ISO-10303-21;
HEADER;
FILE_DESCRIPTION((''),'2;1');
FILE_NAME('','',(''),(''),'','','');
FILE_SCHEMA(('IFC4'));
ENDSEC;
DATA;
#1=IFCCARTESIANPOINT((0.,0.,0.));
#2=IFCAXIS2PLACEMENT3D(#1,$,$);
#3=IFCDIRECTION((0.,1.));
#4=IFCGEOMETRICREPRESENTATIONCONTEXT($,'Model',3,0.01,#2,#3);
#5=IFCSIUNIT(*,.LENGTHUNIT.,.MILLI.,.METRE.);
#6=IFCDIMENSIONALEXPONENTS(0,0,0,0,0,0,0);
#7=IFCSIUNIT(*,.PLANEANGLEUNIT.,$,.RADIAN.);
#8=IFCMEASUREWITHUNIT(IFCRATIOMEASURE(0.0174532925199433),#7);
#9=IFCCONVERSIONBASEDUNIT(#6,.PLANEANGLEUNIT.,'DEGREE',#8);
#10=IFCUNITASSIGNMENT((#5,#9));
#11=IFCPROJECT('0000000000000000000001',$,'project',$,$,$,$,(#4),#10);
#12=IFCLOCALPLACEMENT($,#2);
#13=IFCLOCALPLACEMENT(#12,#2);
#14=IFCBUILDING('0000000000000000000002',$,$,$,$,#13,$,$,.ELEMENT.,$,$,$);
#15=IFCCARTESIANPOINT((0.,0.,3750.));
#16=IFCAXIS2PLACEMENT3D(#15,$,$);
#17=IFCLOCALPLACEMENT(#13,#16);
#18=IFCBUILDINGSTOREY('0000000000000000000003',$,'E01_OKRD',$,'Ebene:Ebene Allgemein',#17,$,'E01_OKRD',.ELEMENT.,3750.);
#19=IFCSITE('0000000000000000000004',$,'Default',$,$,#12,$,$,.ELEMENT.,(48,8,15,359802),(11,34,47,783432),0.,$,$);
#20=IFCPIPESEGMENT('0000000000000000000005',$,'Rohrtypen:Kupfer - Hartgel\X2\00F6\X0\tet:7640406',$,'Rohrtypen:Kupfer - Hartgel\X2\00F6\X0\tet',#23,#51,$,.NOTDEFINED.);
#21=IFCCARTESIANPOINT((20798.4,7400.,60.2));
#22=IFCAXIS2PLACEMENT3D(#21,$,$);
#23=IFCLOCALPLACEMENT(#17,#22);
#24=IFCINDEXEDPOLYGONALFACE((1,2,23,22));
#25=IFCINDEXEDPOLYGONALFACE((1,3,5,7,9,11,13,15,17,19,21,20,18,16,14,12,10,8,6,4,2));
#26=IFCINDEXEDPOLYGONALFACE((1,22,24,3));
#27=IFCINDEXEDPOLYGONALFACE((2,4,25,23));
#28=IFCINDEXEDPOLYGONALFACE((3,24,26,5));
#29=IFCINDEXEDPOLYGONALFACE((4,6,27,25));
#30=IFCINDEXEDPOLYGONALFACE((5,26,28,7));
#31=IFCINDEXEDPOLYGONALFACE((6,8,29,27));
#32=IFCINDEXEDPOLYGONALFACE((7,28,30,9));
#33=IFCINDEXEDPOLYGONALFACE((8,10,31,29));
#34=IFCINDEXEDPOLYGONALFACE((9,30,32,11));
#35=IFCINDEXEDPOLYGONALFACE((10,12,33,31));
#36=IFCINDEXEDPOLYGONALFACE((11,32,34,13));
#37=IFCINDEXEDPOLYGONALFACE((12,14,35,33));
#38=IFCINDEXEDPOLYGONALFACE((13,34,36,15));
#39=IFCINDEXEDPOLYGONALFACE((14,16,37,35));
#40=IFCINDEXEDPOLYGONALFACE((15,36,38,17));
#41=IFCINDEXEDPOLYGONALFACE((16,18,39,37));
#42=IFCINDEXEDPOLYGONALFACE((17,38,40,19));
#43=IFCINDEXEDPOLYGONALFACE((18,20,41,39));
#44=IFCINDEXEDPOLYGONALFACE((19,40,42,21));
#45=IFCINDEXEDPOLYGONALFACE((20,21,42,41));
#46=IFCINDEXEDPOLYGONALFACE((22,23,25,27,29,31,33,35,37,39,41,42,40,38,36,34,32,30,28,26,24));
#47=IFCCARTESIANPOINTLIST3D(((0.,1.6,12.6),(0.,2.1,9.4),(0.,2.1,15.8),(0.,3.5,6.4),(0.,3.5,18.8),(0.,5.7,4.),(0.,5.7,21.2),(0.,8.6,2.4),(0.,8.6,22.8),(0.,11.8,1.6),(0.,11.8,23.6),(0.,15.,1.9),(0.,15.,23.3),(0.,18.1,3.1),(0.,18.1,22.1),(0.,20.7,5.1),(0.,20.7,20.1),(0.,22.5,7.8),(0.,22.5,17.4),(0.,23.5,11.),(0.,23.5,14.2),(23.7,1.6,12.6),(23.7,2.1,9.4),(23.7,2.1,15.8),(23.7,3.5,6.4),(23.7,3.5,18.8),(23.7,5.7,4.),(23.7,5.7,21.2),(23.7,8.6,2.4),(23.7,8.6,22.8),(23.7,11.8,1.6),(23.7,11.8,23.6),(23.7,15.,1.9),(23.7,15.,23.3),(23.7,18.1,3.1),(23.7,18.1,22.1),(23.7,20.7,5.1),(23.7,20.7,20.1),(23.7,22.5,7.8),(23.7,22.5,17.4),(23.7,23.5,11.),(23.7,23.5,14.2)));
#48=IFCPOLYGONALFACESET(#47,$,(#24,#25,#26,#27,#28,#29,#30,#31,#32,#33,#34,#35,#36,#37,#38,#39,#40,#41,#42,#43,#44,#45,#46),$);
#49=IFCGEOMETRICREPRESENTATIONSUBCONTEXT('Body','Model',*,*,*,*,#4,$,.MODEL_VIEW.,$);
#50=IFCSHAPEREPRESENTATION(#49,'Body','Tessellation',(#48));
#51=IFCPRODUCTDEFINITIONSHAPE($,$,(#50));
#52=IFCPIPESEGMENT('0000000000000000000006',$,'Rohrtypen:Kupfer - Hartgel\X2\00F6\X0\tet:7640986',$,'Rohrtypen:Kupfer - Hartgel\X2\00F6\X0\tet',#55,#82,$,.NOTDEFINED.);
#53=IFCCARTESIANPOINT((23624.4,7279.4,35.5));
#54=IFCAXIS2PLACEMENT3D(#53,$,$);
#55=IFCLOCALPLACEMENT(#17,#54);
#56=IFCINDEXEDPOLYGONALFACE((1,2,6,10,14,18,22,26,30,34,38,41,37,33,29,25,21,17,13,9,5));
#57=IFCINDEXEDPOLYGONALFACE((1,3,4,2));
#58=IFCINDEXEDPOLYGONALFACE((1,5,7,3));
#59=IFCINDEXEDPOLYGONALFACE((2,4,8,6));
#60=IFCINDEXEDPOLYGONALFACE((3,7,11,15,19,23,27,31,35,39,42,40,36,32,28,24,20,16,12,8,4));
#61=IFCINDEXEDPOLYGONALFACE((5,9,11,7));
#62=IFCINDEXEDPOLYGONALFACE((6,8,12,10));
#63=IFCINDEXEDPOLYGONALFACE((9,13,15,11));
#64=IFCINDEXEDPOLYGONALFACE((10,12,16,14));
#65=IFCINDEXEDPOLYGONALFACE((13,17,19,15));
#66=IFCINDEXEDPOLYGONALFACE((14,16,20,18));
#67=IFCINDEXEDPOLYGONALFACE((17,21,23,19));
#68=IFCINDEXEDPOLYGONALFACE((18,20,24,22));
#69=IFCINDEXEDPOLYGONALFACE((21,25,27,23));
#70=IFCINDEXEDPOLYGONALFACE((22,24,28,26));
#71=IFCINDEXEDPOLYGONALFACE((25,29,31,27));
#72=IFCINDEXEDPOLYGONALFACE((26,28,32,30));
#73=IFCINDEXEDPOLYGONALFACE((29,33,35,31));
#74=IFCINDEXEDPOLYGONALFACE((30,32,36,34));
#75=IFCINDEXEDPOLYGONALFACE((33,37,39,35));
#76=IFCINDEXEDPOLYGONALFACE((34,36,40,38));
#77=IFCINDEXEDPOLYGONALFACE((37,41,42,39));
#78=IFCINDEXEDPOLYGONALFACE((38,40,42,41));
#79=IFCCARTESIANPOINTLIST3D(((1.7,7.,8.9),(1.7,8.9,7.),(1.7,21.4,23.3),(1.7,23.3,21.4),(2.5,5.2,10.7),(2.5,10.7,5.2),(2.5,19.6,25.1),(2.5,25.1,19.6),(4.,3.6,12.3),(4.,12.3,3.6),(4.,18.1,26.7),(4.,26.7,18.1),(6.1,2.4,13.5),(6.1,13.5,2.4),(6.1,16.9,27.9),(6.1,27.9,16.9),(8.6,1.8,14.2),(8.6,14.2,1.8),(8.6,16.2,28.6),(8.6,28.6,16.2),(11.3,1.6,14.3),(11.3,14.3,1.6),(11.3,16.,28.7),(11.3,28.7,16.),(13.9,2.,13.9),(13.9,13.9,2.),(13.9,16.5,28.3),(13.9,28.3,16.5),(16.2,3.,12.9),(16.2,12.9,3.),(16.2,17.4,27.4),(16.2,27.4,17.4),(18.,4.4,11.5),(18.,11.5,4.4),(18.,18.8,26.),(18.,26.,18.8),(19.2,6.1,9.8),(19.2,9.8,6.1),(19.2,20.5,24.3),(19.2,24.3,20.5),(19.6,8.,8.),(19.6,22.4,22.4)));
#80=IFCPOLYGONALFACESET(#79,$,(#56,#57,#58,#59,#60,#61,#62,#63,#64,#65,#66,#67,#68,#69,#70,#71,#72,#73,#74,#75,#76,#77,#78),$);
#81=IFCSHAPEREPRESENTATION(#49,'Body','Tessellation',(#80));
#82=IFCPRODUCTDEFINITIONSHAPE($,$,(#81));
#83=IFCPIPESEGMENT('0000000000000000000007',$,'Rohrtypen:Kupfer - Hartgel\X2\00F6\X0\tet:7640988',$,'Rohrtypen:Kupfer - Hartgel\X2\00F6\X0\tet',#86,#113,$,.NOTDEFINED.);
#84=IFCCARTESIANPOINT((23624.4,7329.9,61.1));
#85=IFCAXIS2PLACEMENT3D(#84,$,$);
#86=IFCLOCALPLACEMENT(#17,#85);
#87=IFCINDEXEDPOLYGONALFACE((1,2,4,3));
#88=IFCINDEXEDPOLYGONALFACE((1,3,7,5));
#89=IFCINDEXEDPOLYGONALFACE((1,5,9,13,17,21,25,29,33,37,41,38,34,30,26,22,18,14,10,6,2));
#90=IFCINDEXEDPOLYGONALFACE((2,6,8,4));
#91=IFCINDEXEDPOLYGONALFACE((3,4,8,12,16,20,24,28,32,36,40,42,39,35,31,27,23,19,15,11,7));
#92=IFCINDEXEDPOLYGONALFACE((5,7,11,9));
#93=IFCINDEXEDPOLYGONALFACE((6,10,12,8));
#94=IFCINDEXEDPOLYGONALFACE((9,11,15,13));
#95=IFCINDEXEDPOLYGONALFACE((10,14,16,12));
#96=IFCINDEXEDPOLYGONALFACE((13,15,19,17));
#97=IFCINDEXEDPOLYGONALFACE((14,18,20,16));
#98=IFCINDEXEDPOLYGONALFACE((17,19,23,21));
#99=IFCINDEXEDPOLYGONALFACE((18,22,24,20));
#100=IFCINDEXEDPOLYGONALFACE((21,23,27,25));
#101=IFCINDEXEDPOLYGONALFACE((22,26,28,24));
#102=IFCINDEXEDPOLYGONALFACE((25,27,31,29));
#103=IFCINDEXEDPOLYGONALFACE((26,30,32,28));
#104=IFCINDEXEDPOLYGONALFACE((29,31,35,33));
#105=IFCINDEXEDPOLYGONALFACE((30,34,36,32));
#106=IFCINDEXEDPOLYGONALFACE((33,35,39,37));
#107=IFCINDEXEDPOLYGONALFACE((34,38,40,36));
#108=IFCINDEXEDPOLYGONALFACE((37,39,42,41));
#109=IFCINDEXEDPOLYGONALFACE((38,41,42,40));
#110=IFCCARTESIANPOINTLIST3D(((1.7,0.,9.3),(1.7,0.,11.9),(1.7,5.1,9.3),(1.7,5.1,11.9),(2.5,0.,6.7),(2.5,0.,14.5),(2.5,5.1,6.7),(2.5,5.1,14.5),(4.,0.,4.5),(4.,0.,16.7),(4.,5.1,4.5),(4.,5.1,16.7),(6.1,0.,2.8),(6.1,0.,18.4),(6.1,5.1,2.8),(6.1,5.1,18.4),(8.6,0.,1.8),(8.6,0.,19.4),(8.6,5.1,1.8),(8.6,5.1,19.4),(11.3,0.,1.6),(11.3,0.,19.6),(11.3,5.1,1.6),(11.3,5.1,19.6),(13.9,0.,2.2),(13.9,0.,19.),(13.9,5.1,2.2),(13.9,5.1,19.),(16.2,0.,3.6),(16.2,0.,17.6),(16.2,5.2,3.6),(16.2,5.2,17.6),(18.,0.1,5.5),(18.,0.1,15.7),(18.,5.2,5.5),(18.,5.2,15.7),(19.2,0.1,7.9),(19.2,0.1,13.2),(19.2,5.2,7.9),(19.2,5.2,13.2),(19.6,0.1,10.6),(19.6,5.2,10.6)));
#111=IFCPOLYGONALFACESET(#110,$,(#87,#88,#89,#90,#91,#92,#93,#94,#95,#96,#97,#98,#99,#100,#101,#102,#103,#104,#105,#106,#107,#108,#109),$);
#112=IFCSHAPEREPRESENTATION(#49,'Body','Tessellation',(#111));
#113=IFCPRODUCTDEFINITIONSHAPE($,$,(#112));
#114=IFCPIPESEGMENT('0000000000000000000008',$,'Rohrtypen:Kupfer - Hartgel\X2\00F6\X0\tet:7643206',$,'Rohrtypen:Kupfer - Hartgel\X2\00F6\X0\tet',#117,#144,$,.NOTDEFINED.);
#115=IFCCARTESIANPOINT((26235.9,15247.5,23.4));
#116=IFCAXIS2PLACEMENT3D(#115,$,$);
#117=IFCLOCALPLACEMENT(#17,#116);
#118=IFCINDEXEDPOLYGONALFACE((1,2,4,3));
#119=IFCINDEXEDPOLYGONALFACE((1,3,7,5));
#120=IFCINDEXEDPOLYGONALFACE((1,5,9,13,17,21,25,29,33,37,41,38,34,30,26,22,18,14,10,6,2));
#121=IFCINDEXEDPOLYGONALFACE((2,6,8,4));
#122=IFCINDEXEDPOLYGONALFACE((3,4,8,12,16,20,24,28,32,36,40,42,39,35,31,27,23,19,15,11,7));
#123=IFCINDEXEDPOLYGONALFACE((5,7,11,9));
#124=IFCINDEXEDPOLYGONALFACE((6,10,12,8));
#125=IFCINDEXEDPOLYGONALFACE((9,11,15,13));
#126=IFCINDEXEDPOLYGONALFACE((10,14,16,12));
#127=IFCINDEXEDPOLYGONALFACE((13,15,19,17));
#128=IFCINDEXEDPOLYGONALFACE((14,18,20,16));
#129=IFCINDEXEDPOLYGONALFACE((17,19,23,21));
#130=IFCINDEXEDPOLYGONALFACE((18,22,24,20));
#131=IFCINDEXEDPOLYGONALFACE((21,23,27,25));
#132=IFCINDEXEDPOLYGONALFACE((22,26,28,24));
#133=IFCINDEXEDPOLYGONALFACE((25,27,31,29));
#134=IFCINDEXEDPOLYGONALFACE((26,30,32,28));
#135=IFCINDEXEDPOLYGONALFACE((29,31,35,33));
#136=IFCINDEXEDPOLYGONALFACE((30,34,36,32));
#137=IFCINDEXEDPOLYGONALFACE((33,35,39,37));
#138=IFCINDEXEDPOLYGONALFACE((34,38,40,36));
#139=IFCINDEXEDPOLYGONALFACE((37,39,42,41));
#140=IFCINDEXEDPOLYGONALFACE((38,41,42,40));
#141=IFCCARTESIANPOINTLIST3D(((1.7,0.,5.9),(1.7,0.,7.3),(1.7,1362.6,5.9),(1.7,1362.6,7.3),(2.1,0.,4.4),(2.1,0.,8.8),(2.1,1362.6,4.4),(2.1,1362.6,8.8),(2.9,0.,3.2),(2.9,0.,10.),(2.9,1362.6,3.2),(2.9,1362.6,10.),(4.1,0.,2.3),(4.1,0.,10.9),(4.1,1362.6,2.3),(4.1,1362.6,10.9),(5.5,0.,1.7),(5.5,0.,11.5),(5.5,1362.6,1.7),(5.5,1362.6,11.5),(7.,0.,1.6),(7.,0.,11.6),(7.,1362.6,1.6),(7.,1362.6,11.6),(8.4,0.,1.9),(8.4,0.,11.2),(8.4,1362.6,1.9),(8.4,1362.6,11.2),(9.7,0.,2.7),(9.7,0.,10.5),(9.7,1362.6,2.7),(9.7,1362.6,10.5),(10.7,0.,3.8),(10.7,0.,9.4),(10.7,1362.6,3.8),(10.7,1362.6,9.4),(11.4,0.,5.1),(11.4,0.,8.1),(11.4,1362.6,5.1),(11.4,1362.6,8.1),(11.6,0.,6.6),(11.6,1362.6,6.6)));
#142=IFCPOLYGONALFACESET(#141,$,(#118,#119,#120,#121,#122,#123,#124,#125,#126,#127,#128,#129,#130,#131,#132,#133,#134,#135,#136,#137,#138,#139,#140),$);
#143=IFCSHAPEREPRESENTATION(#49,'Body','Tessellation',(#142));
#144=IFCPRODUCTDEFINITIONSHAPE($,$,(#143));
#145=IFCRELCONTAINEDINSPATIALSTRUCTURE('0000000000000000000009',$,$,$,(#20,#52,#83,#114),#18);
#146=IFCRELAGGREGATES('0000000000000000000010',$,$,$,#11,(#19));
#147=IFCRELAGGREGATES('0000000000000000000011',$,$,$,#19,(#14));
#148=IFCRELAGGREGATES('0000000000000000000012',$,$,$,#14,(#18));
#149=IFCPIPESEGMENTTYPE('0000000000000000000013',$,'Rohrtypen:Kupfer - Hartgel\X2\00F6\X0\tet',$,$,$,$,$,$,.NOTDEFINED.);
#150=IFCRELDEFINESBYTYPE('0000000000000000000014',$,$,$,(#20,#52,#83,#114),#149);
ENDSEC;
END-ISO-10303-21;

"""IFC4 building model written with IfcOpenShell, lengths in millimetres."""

from ifc_helpers import new_model, entity, si_unit, converted_unit, direction, frame, frame_2d, origin, origin_2d_with_axis, place, context, subcontext, project, spatial, circle, extrude, type_object, element, save


model = new_model("IFC4")

# Units and contexts
model_context = context("Model", 3, precision=0.01, world=origin(), true_north=direction((0.0, 1.0)))
body_context = subcontext(model_context, "Body", "Model", "MODEL_VIEW")
ifc_project = project(units=[si_unit("LENGTHUNIT", "METRE", prefix="MILLI"), converted_unit("PLANEANGLEUNIT", "DEGREE", entity("IfcRatioMeasure", 0.0174532925199433), si_unit("PLANEANGLEUNIT", "RADIAN"), dimensions=[0, 0, 0, 0, 0, 0, 0])], contexts=[model_context])

# Site, building, storey
site_placement = place(None, origin())
site = spatial("IfcSite", under=ifc_project, at=site_placement, Name="Default", CompositionType="ELEMENT", RefLatitude=(48, 8, 15, 359802), RefLongitude=(11, 34, 47, 783432), RefElevation=0.0)
building_placement = place(site_placement, origin())
building = spatial("IfcBuilding", under=site, at=building_placement, CompositionType="ELEMENT")
storey_placement = place(building_placement, frame((0.0, 0.0, 3750.0)))
storey = spatial("IfcBuildingStorey", under=building, at=storey_placement, Name="E01_OKRD", ObjectType="Ebene:Ebene Allgemein", LongName="E01_OKRD", CompositionType="ELEMENT", Elevation=3750.0)

# Pipe segments
pipe_segment_type = type_object("IfcPipeSegmentType", Name="Rohrtypen:Kupfer - Hartgelötet", PredefinedType="NOTDEFINED")
pipe_segment_1_placement = place(storey_placement, frame((20798.4, 7400.0, 60.2)))
element("IfcPipeSegment", 1, at=pipe_segment_1_placement, inside=storey, type_object=pipe_segment_type, Name="Rohrtypen:Kupfer - Hartgelötet:7640406", ObjectType="Rohrtypen:Kupfer - Hartgelötet", PredefinedType="NOTDEFINED", context=body_context, shape_type="SweptSolid", body=[
    extrude(circle(Radius=11.0, at=frame_2d((0.0, 0.0), x_axis=(1.0, 0.0))), frame((0.0, 12.6, 12.6), z_axis=(1.0, 0.0, 0.0), x_axis=(0.0, -1.0, 0.0)), (0.0, 0.0, 1.0), 23.7),
])
pipe_segment_2_placement = place(storey_placement, frame((23624.4, 7279.4, 35.5)))
element("IfcPipeSegment", 2, at=pipe_segment_2_placement, inside=storey, type_object=pipe_segment_type, Name="Rohrtypen:Kupfer - Hartgelötet:7640986", ObjectType="Rohrtypen:Kupfer - Hartgelötet", PredefinedType="NOTDEFINED", context=body_context, shape_type="SweptSolid", body=[
    extrude(circle(Radius=9.0, at=frame_2d((0.0, 0.0), x_axis=(1.0, 0.0))), frame((10.6, 8.0, 8.0), z_axis=(0.0, 0.707107, 0.707107), x_axis=(1.0, 0.0, 0.0)), (0.0, 0.0, 1.0), 20.4),
])
pipe_segment_3_placement = place(storey_placement, frame((23624.4, 7329.9, 61.1)))
element("IfcPipeSegment", 3, at=pipe_segment_3_placement, inside=storey, type_object=pipe_segment_type, Name="Rohrtypen:Kupfer - Hartgelötet:7640988", ObjectType="Rohrtypen:Kupfer - Hartgelötet", PredefinedType="NOTDEFINED", context=body_context, shape_type="SweptSolid", body=[
    extrude(circle(Radius=9.0, at=origin_2d_with_axis()), frame((10.6, 0.0, 10.6), z_axis=(-0.00319, 0.999995, 0.0), x_axis=(0.999995, 0.00319, -0.000001)), (0.0, 0.0, 1.0), 5.1),
])
pipe_segment_4_placement = place(storey_placement, frame((26235.9, 15247.5, 23.4)))
element("IfcPipeSegment", 4, at=pipe_segment_4_placement, inside=storey, type_object=pipe_segment_type, Name="Rohrtypen:Kupfer - Hartgelötet:7643206", ObjectType="Rohrtypen:Kupfer - Hartgelötet", PredefinedType="NOTDEFINED", context=body_context, shape_type="SweptSolid", body=[
    extrude(circle(Radius=5.0, at=origin_2d_with_axis()), frame((6.6, 0.0, 6.6), z_axis=(0.0, 1.0, 0.0), x_axis=(1.0, 0.0, 0.0)), (0.0, 0.0, 1.0), 1362.6),
])

save(model, "model.ifc")
